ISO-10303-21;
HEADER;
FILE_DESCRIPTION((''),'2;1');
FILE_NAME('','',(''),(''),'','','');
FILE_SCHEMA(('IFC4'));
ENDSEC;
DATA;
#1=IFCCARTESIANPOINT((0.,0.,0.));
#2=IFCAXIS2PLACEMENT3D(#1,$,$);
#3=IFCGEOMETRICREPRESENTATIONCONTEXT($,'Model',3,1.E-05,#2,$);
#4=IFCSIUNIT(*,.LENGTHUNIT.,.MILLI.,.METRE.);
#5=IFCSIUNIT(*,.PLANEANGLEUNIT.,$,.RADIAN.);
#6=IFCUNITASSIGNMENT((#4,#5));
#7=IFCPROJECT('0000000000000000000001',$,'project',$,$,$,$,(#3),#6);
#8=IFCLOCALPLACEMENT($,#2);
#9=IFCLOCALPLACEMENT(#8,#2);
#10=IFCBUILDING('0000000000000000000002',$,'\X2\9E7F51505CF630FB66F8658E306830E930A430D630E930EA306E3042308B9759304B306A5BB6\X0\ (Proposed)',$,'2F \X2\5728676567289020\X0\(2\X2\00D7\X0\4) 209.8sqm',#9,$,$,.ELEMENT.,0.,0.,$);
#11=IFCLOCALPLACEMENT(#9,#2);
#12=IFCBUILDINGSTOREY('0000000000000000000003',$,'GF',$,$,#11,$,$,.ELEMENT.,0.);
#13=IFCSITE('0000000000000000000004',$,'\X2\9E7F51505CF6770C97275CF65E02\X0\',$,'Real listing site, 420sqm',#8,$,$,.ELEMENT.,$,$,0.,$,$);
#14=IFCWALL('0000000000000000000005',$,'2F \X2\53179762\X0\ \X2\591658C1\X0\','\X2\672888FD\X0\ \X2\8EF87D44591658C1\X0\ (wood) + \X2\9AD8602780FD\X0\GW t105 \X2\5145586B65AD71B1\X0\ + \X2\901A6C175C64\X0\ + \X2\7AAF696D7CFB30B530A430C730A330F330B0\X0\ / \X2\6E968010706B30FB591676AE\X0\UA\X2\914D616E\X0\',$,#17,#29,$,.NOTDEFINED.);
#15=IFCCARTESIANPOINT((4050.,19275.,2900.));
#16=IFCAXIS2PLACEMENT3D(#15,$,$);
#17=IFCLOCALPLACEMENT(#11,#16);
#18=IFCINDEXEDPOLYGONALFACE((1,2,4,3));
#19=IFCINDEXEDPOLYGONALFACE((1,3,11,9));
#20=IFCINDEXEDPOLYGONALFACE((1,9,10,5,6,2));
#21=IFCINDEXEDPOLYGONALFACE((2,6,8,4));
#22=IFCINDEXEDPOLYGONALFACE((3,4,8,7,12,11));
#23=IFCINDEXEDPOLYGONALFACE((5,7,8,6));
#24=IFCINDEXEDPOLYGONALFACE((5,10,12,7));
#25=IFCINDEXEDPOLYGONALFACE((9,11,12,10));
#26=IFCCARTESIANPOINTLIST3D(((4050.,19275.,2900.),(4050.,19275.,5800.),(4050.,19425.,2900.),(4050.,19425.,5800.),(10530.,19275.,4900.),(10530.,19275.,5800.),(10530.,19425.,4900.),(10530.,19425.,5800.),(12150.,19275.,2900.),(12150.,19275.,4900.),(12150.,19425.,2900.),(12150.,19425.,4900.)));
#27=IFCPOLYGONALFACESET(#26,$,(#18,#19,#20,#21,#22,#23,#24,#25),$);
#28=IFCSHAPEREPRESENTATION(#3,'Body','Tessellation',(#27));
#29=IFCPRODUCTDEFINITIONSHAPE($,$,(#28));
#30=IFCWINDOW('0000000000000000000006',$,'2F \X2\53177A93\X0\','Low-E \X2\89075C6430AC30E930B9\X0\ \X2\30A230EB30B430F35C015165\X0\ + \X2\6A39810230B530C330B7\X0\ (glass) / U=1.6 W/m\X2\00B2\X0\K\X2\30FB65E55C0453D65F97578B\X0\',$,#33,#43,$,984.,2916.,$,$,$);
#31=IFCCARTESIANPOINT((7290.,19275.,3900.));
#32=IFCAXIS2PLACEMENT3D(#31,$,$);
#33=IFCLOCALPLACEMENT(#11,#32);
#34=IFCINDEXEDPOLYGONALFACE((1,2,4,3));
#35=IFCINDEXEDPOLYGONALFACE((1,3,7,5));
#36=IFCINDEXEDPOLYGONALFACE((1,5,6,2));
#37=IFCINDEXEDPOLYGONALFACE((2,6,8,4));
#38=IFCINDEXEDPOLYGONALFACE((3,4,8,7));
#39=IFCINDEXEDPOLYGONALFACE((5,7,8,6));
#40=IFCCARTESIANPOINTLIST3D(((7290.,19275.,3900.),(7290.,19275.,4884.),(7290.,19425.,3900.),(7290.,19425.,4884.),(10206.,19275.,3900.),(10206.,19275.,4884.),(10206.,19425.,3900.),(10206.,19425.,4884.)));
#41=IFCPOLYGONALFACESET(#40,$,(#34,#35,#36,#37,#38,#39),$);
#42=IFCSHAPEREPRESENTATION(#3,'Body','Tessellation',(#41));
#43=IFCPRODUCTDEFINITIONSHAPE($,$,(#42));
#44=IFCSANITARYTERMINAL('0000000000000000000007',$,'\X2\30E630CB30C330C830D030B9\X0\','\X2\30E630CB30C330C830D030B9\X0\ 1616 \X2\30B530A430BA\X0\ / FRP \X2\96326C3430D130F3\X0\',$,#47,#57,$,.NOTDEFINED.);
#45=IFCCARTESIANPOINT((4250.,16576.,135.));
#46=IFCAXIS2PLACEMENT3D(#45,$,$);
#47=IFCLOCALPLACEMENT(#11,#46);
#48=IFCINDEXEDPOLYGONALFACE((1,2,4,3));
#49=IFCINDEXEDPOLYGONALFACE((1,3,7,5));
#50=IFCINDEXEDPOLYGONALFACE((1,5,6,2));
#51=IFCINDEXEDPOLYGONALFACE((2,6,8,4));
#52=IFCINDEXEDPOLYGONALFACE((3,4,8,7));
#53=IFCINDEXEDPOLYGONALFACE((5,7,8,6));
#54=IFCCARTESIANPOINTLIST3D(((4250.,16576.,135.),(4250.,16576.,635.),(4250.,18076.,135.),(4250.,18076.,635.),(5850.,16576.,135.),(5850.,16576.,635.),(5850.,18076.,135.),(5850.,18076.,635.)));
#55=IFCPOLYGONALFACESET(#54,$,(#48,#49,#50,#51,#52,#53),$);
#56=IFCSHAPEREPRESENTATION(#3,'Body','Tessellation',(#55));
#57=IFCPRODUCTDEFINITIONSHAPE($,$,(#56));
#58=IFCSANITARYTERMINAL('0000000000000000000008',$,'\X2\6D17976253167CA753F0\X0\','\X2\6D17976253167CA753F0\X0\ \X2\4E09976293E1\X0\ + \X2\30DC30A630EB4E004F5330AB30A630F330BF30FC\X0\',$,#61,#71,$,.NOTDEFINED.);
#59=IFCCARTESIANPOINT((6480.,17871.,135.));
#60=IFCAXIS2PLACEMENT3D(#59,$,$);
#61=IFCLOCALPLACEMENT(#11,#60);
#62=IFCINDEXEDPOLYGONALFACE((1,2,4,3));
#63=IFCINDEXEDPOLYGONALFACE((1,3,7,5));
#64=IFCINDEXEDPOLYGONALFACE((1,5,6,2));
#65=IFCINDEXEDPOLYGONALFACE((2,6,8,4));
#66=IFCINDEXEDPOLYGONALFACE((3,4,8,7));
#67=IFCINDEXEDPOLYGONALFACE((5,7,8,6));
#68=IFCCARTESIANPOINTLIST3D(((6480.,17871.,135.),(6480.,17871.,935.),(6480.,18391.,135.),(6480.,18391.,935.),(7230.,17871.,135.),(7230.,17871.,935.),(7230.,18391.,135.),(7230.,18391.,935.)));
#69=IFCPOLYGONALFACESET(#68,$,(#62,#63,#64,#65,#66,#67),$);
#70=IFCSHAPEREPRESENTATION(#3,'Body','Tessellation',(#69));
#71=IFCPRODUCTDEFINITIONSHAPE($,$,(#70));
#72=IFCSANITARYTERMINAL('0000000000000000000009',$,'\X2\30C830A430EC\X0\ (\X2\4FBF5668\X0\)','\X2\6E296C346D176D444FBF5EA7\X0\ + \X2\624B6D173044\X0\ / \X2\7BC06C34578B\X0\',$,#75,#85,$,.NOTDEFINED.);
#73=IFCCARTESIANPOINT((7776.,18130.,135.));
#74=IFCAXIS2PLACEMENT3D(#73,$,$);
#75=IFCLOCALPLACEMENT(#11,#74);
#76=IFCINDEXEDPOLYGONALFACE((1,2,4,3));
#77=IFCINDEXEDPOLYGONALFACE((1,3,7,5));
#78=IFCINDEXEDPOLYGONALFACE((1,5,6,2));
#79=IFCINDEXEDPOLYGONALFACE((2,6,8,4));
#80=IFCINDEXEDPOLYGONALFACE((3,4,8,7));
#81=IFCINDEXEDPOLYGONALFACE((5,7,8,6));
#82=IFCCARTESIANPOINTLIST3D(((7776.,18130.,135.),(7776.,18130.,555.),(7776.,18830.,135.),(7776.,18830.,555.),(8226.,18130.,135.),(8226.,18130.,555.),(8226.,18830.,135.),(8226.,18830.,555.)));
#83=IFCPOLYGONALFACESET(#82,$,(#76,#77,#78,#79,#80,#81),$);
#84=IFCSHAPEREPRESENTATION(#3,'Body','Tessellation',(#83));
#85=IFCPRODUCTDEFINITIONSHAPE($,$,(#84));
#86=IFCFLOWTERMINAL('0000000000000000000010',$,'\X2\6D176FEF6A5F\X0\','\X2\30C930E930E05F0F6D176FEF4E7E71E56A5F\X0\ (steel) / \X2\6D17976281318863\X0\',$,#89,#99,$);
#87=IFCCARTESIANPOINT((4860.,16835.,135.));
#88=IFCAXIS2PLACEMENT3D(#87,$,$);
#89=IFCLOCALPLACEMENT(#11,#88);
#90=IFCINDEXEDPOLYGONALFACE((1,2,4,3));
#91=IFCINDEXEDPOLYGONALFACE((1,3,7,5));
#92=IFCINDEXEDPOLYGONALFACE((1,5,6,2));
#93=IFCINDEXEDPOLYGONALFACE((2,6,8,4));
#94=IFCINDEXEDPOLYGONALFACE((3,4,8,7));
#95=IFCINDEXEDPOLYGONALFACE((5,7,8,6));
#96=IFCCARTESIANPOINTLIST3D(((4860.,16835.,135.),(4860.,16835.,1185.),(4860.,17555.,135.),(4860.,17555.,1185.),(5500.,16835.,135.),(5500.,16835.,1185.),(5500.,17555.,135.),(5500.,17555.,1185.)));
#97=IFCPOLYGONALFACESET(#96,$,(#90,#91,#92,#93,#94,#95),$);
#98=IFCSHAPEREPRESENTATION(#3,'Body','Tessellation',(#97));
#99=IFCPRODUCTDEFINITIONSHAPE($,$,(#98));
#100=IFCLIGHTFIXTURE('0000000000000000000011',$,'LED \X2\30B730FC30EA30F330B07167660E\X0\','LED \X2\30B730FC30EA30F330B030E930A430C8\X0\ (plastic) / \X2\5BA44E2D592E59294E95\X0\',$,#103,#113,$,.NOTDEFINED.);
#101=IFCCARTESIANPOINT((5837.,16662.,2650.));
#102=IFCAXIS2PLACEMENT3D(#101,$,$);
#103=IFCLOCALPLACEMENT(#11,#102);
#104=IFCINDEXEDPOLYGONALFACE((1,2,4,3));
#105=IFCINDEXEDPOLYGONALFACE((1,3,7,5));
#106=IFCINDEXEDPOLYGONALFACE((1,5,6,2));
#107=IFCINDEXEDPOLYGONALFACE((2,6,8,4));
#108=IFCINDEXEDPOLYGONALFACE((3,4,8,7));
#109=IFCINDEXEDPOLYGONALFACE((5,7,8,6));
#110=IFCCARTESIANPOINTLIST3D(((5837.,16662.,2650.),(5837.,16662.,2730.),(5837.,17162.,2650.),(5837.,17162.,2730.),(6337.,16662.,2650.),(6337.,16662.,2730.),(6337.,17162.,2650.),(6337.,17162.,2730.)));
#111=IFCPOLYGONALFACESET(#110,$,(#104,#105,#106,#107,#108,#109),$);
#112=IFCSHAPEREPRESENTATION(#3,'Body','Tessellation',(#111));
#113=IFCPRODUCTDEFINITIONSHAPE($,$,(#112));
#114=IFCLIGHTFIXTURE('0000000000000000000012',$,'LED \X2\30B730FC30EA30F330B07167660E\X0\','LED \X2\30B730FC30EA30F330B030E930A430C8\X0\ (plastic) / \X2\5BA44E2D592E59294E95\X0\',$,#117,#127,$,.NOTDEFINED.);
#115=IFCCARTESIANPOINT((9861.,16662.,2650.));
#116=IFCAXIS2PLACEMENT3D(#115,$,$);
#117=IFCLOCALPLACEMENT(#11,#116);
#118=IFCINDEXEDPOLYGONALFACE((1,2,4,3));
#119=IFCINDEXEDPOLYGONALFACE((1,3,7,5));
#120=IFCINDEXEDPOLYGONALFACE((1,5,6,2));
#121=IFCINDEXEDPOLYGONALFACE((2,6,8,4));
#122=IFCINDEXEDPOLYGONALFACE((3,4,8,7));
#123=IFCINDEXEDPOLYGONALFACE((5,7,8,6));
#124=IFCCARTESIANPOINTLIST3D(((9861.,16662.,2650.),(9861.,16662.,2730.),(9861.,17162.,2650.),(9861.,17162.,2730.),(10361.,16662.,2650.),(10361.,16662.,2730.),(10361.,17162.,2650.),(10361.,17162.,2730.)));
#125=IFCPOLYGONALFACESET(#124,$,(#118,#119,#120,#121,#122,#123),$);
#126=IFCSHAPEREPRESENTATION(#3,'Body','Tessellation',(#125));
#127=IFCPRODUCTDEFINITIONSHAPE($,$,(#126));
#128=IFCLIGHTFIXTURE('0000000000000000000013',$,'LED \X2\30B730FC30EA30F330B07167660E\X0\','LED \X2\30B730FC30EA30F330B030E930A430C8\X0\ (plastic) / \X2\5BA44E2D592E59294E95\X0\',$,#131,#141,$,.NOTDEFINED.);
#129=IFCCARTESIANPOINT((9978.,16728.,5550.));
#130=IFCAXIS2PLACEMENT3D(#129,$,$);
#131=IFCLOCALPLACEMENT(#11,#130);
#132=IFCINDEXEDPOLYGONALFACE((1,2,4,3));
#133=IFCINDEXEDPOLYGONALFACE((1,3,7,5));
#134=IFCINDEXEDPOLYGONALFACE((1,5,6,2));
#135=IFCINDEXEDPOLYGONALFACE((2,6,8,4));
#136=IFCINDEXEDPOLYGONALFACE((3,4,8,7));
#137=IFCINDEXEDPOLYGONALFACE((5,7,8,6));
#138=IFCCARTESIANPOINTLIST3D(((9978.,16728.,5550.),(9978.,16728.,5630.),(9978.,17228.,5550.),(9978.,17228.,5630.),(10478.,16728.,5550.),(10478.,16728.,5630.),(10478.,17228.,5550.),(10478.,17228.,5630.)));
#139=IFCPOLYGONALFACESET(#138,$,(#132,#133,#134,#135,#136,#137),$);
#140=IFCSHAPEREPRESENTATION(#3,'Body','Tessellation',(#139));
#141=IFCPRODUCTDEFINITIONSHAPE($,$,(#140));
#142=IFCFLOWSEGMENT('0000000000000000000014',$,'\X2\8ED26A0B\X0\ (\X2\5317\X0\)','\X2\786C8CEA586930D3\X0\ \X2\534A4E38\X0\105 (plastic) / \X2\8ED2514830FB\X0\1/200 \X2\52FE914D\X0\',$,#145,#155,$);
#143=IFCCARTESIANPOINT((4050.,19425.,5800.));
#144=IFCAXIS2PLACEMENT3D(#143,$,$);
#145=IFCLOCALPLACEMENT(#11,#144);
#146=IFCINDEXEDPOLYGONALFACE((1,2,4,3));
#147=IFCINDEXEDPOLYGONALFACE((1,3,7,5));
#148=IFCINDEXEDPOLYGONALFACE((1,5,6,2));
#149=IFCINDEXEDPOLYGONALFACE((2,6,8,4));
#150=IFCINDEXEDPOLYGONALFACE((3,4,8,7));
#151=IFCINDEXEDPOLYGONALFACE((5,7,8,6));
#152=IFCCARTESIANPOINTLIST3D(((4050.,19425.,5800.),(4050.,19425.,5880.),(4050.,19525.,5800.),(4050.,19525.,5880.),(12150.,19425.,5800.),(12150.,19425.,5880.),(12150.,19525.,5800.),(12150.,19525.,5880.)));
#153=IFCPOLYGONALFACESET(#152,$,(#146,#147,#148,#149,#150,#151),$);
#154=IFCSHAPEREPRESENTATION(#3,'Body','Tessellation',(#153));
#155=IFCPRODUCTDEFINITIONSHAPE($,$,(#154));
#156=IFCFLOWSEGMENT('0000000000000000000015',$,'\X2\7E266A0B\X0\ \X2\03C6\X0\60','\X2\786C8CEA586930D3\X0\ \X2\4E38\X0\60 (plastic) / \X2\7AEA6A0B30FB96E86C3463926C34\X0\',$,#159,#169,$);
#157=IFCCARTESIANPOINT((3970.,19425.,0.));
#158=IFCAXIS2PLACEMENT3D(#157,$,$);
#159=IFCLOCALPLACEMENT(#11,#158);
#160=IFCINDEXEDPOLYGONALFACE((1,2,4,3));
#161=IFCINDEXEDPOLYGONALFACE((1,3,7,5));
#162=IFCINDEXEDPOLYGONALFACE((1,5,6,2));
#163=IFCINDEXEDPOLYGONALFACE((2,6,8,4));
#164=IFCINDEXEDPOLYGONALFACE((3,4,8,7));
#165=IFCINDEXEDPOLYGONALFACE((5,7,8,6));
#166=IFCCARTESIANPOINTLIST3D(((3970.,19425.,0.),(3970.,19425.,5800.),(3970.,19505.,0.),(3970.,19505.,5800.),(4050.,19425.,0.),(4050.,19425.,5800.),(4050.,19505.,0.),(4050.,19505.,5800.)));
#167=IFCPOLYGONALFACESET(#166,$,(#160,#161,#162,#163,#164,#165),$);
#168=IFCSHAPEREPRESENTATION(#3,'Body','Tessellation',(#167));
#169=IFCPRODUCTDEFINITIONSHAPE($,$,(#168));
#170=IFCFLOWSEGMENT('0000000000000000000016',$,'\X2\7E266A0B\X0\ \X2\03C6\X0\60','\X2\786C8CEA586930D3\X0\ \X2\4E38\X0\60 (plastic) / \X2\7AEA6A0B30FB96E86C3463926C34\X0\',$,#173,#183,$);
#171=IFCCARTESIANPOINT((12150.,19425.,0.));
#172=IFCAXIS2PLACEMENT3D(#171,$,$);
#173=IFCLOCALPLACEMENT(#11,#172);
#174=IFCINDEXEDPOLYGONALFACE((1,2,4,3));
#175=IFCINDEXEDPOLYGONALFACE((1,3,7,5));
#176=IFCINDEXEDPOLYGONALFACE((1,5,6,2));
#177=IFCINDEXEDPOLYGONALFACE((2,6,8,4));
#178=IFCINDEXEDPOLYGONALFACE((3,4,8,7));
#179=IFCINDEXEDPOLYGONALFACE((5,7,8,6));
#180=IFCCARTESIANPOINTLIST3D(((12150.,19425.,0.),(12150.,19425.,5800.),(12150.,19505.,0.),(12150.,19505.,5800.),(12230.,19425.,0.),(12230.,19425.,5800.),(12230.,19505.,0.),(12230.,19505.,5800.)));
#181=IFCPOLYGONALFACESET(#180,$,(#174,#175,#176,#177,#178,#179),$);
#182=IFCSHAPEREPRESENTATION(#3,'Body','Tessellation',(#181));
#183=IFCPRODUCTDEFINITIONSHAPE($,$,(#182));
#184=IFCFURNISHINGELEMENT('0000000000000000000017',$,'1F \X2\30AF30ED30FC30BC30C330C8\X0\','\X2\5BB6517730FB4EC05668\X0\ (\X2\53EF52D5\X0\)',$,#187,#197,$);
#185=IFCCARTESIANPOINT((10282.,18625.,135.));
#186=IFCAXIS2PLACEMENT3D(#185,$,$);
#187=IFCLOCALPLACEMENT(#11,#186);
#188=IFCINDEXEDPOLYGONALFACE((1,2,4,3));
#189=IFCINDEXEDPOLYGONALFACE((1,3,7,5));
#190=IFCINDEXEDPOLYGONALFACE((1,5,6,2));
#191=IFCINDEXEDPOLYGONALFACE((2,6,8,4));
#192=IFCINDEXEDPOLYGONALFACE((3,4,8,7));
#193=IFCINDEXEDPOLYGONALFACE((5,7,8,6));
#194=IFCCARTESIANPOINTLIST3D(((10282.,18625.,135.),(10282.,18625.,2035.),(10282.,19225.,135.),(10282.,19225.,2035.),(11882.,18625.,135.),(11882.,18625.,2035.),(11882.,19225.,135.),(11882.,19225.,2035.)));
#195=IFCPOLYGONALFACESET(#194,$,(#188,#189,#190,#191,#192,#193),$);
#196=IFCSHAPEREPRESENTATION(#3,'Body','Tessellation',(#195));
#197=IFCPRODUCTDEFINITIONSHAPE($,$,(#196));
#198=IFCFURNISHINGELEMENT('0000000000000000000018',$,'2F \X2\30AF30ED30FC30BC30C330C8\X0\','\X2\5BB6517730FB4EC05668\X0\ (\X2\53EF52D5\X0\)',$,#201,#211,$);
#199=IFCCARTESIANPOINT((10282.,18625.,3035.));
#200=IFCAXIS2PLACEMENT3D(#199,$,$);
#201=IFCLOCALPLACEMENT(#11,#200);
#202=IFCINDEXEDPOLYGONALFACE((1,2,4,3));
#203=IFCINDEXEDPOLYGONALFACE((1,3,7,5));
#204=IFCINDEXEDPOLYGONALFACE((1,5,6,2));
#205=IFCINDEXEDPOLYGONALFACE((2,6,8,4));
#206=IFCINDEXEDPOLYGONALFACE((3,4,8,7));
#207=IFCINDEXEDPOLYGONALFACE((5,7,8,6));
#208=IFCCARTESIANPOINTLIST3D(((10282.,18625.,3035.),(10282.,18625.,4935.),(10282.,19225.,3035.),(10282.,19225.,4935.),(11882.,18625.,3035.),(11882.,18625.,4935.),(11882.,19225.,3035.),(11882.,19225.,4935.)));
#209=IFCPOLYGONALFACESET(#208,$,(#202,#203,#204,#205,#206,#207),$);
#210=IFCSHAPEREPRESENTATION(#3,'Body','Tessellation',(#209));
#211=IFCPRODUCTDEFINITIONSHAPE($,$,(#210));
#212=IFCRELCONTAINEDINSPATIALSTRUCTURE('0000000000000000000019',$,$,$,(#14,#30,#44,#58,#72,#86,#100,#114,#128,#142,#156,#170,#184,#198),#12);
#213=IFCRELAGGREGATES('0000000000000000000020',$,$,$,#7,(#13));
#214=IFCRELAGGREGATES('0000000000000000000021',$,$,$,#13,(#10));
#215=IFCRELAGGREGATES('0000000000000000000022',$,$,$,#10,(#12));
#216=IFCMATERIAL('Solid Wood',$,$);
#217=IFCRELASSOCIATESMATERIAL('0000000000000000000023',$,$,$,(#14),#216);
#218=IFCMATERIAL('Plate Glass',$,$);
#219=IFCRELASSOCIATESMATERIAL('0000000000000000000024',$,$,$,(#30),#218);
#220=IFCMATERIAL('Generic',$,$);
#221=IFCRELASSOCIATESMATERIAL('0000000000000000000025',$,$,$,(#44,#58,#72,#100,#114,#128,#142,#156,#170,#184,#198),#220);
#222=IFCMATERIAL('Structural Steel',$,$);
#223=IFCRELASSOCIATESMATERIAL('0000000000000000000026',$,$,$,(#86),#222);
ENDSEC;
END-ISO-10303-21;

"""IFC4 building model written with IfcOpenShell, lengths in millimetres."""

from ifc_helpers import new_model, si_unit, frame, frame_2d, origin, place, context, project, spatial, rectangle, extrude, material, element, fill, save


model = new_model("IFC4")

# Units and contexts
model_context = context("Model", 3, precision=1e-05, world=origin())
ifc_project = project(units=[si_unit("LENGTHUNIT", "METRE", prefix="MILLI"), si_unit("PLANEANGLEUNIT", "RADIAN")], contexts=[model_context])

# Site, building, storey
site_placement = place(None, origin())
site = spatial("IfcSite", under=ifc_project, at=site_placement, Name="鹿児島県霧島市", ObjectType="Real listing site, 420sqm", CompositionType="ELEMENT", RefElevation=0.0)
building_placement = place(site_placement, origin())
building = spatial("IfcBuilding", under=site, at=building_placement, Name="鹿児島・書斎とライブラリのある静かな家 (Proposed)", ObjectType="2F 在来木造(2×4) 209.8sqm", CompositionType="ELEMENT", ElevationOfRefHeight=0.0, ElevationOfTerrain=0.0)
storey_placement = place(building_placement, origin())
storey = spatial("IfcBuildingStorey", under=building, at=storey_placement, Name="GF", CompositionType="ELEMENT", Elevation=0.0)

# Shared definitions
ifc_material_1 = material(Name="Solid Wood")

# Shared definitions
ifc_material_2 = material(Name="Plate Glass")

# Wall, opening, window
wall_1_placement = place(storey_placement, frame((4050.0, 19275.0, 2900.0)))
wall_1 = element("IfcWall", 1, at=wall_1_placement, inside=storey, material=ifc_material_1, Name="2F 北面 外壁", Description="木製 軸組外壁 (wood) + 高性能GW t105 充填断熱 + 通気層 + 窯業系サイディング / 準耐火・外皮UA配慮", PredefinedType="NOTDEFINED", context=model_context, shape_type="SweptSolid", body=[
    extrude(rectangle(XDim=8100.0, YDim=150.0, at=frame_2d((4050.0, 75.0))), frame((4050.0, 19275.0, 2900.0)), (0.0, 0.0, 1.0), 2900.0),
])
opening_1_placement = place(storey_placement, frame((7290.0, 19275.0, 3900.0)))
opening_1 = element("IfcOpeningElement", 2, at=opening_1_placement, cuts=wall_1, PredefinedType="NOTDEFINED", context=model_context, shape_type="SweptSolid", body=[
    extrude(rectangle(XDim=2916.0, YDim=150.0, at=frame_2d((1458.0, 75.0))), frame((7290.0, 19275.0, 3900.0)), (0.0, 0.0, 1.0), 984.0),
])
window_1_placement = place(storey_placement, frame((7290.0, 19275.0, 3900.0)))
window_1 = element("IfcWindow", 3, at=window_1_placement, inside=storey, material=ifc_material_2, Name="2F 北窓", Description="Low-E 複層ガラス アルゴン封入 + 樹脂サッシ (glass) / U=1.6 W/m²K・日射取得型", OverallHeight=984.0, OverallWidth=2916.0, context=model_context, shape_type="SweptSolid", body=[
    extrude(rectangle(XDim=2916.0, YDim=150.0, at=frame_2d((1458.0, 75.0))), frame((7290.0, 19275.0, 3900.0)), (0.0, 0.0, 1.0), 984.0),
])
fill(opening_1, window_1)

# Sanitary terminals
ifc_material_3 = material(Name="Generic")
sanitary_terminal_1_placement = place(storey_placement, frame((4250.0, 16576.0, 135.0)))
element("IfcSanitaryTerminal", 4, at=sanitary_terminal_1_placement, inside=storey, material=ifc_material_3, Name="ユニットバス", Description="ユニットバス 1616 サイズ / FRP 防水パン", PredefinedType="NOTDEFINED", context=model_context, shape_type="SweptSolid", body=[
    extrude(rectangle(XDim=1600.0, YDim=1500.0, at=frame_2d((800.0, 750.0))), frame((4250.0, 16576.0, 135.0)), (0.0, 0.0, 1.0), 500.0),
])
sanitary_terminal_2_placement = place(storey_placement, frame((6480.0, 17871.0, 135.0)))
element("IfcSanitaryTerminal", 5, at=sanitary_terminal_2_placement, inside=storey, material=ifc_material_3, Name="洗面化粧台", Description="洗面化粧台 三面鏡 + ボウル一体カウンター", PredefinedType="NOTDEFINED", context=model_context, shape_type="SweptSolid", body=[
    extrude(rectangle(XDim=750.0, YDim=520.0, at=frame_2d((375.0, 260.0))), frame((6480.0, 17871.0, 135.0)), (0.0, 0.0, 1.0), 800.0),
])
sanitary_terminal_3_placement = place(storey_placement, frame((7776.0, 18130.0, 135.0)))
element("IfcSanitaryTerminal", 6, at=sanitary_terminal_3_placement, inside=storey, material=ifc_material_3, Name="トイレ (便器)", Description="温水洗浄便座 + 手洗い / 節水型", PredefinedType="NOTDEFINED", context=model_context, shape_type="SweptSolid", body=[
    extrude(rectangle(XDim=450.0, YDim=700.0, at=frame_2d((225.0, 350.0))), frame((7776.0, 18130.0, 135.0)), (0.0, 0.0, 1.0), 420.0),
])

# Flow terminal
ifc_material_4 = material(Name="Structural Steel")
flow_terminal_placement = place(storey_placement, frame((4860.0, 16835.0, 135.0)))
element("IfcFlowTerminal", 7, at=flow_terminal_placement, inside=storey, material=ifc_material_4, Name="洗濯機", Description="ドラム式洗濯乾燥機 (steel) / 洗面脱衣", context=model_context, shape_type="SweptSolid", body=[
    extrude(rectangle(XDim=640.0, YDim=720.0, at=frame_2d((320.0, 360.0))), frame((4860.0, 16835.0, 135.0)), (0.0, 0.0, 1.0), 1050.0),
])

# Light fixtures
light_fixture_1_placement = place(storey_placement, frame((5837.0, 16662.0, 2650.0)))
element("IfcLightFixture", 8, at=light_fixture_1_placement, inside=storey, material=ifc_material_3, Name="LED シーリング照明", Description="LED シーリングライト (plastic) / 室中央天井", PredefinedType="NOTDEFINED", context=model_context, shape_type="SweptSolid", body=[
    extrude(rectangle(XDim=500.0, YDim=500.0, at=frame_2d((250.0, 250.0))), frame((5837.0, 16662.0, 2650.0)), (0.0, 0.0, 1.0), 80.0),
])
light_fixture_2_placement = place(storey_placement, frame((9861.0, 16662.0, 2650.0)))
element("IfcLightFixture", 9, at=light_fixture_2_placement, inside=storey, material=ifc_material_3, Name="LED シーリング照明", Description="LED シーリングライト (plastic) / 室中央天井", PredefinedType="NOTDEFINED", context=model_context, shape_type="SweptSolid", body=[
    extrude(rectangle(XDim=500.0, YDim=500.0, at=frame_2d((250.0, 250.0))), frame((9861.0, 16662.0, 2650.0)), (0.0, 0.0, 1.0), 80.0),
])
light_fixture_3_placement = place(storey_placement, frame((9978.0, 16728.0, 5550.0)))
element("IfcLightFixture", 10, at=light_fixture_3_placement, inside=storey, material=ifc_material_3, Name="LED シーリング照明", Description="LED シーリングライト (plastic) / 室中央天井", PredefinedType="NOTDEFINED", context=model_context, shape_type="SweptSolid", body=[
    extrude(rectangle(XDim=500.0, YDim=500.0, at=frame_2d((250.0, 250.0))), frame((9978.0, 16728.0, 5550.0)), (0.0, 0.0, 1.0), 80.0),
])

# Flow segments
flow_segment_1_placement = place(storey_placement, frame((4050.0, 19425.0, 5800.0)))
element("IfcFlowSegment", 11, at=flow_segment_1_placement, inside=storey, material=ifc_material_3, Name="軒樋 (北)", Description="硬質塩ビ 半丸105 (plastic) / 軒先・1/200 勾配", context=model_context, shape_type="SweptSolid", body=[
    extrude(rectangle(XDim=8100.0, YDim=100.0, at=frame_2d((4050.0, 50.0))), frame((4050.0, 19425.0, 5800.0)), (0.0, 0.0, 1.0), 80.0),
])
flow_segment_2_placement = place(storey_placement, frame((3970.0, 19425.0, 0.0)))
element("IfcFlowSegment", 12, at=flow_segment_2_placement, inside=storey, material=ifc_material_3, Name="縦樋 φ60", Description="硬質塩ビ 丸60 (plastic) / 竪樋・雨水排水", context=model_context, shape_type="SweptSolid", body=[
    extrude(rectangle(XDim=80.0, YDim=80.0, at=frame_2d((40.0, 40.0))), frame((3970.0, 19425.0, 0.0)), (0.0, 0.0, 1.0), 5800.0),
])
flow_segment_3_placement = place(storey_placement, frame((12150.0, 19425.0, 0.0)))
element("IfcFlowSegment", 13, at=flow_segment_3_placement, inside=storey, material=ifc_material_3, Name="縦樋 φ60", Description="硬質塩ビ 丸60 (plastic) / 竪樋・雨水排水", context=model_context, shape_type="SweptSolid", body=[
    extrude(rectangle(XDim=80.0, YDim=80.0, at=frame_2d((40.0, 40.0))), frame((12150.0, 19425.0, 0.0)), (0.0, 0.0, 1.0), 5800.0),
])

# Furnishing elements
furnishing_1_placement = place(storey_placement, frame((10282.0, 18625.0, 135.0)))
element("IfcFurnishingElement", 14, at=furnishing_1_placement, inside=storey, material=ifc_material_3, Name="1F クローゼット", Description="家具・什器 (可動)", context=model_context, shape_type="SweptSolid", body=[
    extrude(rectangle(XDim=1600.0, YDim=600.0, at=frame_2d((800.0, 300.0))), frame((10282.0, 18625.0, 135.0)), (0.0, 0.0, 1.0), 1900.0),
])
furnishing_2_placement = place(storey_placement, frame((10282.0, 18625.0, 3035.0)))
element("IfcFurnishingElement", 15, at=furnishing_2_placement, inside=storey, material=ifc_material_3, Name="2F クローゼット", Description="家具・什器 (可動)", context=model_context, shape_type="SweptSolid", body=[
    extrude(rectangle(XDim=1600.0, YDim=600.0, at=frame_2d((800.0, 300.0))), frame((10282.0, 18625.0, 3035.0)), (0.0, 0.0, 1.0), 1900.0),
])

save(model, "model.ifc")
